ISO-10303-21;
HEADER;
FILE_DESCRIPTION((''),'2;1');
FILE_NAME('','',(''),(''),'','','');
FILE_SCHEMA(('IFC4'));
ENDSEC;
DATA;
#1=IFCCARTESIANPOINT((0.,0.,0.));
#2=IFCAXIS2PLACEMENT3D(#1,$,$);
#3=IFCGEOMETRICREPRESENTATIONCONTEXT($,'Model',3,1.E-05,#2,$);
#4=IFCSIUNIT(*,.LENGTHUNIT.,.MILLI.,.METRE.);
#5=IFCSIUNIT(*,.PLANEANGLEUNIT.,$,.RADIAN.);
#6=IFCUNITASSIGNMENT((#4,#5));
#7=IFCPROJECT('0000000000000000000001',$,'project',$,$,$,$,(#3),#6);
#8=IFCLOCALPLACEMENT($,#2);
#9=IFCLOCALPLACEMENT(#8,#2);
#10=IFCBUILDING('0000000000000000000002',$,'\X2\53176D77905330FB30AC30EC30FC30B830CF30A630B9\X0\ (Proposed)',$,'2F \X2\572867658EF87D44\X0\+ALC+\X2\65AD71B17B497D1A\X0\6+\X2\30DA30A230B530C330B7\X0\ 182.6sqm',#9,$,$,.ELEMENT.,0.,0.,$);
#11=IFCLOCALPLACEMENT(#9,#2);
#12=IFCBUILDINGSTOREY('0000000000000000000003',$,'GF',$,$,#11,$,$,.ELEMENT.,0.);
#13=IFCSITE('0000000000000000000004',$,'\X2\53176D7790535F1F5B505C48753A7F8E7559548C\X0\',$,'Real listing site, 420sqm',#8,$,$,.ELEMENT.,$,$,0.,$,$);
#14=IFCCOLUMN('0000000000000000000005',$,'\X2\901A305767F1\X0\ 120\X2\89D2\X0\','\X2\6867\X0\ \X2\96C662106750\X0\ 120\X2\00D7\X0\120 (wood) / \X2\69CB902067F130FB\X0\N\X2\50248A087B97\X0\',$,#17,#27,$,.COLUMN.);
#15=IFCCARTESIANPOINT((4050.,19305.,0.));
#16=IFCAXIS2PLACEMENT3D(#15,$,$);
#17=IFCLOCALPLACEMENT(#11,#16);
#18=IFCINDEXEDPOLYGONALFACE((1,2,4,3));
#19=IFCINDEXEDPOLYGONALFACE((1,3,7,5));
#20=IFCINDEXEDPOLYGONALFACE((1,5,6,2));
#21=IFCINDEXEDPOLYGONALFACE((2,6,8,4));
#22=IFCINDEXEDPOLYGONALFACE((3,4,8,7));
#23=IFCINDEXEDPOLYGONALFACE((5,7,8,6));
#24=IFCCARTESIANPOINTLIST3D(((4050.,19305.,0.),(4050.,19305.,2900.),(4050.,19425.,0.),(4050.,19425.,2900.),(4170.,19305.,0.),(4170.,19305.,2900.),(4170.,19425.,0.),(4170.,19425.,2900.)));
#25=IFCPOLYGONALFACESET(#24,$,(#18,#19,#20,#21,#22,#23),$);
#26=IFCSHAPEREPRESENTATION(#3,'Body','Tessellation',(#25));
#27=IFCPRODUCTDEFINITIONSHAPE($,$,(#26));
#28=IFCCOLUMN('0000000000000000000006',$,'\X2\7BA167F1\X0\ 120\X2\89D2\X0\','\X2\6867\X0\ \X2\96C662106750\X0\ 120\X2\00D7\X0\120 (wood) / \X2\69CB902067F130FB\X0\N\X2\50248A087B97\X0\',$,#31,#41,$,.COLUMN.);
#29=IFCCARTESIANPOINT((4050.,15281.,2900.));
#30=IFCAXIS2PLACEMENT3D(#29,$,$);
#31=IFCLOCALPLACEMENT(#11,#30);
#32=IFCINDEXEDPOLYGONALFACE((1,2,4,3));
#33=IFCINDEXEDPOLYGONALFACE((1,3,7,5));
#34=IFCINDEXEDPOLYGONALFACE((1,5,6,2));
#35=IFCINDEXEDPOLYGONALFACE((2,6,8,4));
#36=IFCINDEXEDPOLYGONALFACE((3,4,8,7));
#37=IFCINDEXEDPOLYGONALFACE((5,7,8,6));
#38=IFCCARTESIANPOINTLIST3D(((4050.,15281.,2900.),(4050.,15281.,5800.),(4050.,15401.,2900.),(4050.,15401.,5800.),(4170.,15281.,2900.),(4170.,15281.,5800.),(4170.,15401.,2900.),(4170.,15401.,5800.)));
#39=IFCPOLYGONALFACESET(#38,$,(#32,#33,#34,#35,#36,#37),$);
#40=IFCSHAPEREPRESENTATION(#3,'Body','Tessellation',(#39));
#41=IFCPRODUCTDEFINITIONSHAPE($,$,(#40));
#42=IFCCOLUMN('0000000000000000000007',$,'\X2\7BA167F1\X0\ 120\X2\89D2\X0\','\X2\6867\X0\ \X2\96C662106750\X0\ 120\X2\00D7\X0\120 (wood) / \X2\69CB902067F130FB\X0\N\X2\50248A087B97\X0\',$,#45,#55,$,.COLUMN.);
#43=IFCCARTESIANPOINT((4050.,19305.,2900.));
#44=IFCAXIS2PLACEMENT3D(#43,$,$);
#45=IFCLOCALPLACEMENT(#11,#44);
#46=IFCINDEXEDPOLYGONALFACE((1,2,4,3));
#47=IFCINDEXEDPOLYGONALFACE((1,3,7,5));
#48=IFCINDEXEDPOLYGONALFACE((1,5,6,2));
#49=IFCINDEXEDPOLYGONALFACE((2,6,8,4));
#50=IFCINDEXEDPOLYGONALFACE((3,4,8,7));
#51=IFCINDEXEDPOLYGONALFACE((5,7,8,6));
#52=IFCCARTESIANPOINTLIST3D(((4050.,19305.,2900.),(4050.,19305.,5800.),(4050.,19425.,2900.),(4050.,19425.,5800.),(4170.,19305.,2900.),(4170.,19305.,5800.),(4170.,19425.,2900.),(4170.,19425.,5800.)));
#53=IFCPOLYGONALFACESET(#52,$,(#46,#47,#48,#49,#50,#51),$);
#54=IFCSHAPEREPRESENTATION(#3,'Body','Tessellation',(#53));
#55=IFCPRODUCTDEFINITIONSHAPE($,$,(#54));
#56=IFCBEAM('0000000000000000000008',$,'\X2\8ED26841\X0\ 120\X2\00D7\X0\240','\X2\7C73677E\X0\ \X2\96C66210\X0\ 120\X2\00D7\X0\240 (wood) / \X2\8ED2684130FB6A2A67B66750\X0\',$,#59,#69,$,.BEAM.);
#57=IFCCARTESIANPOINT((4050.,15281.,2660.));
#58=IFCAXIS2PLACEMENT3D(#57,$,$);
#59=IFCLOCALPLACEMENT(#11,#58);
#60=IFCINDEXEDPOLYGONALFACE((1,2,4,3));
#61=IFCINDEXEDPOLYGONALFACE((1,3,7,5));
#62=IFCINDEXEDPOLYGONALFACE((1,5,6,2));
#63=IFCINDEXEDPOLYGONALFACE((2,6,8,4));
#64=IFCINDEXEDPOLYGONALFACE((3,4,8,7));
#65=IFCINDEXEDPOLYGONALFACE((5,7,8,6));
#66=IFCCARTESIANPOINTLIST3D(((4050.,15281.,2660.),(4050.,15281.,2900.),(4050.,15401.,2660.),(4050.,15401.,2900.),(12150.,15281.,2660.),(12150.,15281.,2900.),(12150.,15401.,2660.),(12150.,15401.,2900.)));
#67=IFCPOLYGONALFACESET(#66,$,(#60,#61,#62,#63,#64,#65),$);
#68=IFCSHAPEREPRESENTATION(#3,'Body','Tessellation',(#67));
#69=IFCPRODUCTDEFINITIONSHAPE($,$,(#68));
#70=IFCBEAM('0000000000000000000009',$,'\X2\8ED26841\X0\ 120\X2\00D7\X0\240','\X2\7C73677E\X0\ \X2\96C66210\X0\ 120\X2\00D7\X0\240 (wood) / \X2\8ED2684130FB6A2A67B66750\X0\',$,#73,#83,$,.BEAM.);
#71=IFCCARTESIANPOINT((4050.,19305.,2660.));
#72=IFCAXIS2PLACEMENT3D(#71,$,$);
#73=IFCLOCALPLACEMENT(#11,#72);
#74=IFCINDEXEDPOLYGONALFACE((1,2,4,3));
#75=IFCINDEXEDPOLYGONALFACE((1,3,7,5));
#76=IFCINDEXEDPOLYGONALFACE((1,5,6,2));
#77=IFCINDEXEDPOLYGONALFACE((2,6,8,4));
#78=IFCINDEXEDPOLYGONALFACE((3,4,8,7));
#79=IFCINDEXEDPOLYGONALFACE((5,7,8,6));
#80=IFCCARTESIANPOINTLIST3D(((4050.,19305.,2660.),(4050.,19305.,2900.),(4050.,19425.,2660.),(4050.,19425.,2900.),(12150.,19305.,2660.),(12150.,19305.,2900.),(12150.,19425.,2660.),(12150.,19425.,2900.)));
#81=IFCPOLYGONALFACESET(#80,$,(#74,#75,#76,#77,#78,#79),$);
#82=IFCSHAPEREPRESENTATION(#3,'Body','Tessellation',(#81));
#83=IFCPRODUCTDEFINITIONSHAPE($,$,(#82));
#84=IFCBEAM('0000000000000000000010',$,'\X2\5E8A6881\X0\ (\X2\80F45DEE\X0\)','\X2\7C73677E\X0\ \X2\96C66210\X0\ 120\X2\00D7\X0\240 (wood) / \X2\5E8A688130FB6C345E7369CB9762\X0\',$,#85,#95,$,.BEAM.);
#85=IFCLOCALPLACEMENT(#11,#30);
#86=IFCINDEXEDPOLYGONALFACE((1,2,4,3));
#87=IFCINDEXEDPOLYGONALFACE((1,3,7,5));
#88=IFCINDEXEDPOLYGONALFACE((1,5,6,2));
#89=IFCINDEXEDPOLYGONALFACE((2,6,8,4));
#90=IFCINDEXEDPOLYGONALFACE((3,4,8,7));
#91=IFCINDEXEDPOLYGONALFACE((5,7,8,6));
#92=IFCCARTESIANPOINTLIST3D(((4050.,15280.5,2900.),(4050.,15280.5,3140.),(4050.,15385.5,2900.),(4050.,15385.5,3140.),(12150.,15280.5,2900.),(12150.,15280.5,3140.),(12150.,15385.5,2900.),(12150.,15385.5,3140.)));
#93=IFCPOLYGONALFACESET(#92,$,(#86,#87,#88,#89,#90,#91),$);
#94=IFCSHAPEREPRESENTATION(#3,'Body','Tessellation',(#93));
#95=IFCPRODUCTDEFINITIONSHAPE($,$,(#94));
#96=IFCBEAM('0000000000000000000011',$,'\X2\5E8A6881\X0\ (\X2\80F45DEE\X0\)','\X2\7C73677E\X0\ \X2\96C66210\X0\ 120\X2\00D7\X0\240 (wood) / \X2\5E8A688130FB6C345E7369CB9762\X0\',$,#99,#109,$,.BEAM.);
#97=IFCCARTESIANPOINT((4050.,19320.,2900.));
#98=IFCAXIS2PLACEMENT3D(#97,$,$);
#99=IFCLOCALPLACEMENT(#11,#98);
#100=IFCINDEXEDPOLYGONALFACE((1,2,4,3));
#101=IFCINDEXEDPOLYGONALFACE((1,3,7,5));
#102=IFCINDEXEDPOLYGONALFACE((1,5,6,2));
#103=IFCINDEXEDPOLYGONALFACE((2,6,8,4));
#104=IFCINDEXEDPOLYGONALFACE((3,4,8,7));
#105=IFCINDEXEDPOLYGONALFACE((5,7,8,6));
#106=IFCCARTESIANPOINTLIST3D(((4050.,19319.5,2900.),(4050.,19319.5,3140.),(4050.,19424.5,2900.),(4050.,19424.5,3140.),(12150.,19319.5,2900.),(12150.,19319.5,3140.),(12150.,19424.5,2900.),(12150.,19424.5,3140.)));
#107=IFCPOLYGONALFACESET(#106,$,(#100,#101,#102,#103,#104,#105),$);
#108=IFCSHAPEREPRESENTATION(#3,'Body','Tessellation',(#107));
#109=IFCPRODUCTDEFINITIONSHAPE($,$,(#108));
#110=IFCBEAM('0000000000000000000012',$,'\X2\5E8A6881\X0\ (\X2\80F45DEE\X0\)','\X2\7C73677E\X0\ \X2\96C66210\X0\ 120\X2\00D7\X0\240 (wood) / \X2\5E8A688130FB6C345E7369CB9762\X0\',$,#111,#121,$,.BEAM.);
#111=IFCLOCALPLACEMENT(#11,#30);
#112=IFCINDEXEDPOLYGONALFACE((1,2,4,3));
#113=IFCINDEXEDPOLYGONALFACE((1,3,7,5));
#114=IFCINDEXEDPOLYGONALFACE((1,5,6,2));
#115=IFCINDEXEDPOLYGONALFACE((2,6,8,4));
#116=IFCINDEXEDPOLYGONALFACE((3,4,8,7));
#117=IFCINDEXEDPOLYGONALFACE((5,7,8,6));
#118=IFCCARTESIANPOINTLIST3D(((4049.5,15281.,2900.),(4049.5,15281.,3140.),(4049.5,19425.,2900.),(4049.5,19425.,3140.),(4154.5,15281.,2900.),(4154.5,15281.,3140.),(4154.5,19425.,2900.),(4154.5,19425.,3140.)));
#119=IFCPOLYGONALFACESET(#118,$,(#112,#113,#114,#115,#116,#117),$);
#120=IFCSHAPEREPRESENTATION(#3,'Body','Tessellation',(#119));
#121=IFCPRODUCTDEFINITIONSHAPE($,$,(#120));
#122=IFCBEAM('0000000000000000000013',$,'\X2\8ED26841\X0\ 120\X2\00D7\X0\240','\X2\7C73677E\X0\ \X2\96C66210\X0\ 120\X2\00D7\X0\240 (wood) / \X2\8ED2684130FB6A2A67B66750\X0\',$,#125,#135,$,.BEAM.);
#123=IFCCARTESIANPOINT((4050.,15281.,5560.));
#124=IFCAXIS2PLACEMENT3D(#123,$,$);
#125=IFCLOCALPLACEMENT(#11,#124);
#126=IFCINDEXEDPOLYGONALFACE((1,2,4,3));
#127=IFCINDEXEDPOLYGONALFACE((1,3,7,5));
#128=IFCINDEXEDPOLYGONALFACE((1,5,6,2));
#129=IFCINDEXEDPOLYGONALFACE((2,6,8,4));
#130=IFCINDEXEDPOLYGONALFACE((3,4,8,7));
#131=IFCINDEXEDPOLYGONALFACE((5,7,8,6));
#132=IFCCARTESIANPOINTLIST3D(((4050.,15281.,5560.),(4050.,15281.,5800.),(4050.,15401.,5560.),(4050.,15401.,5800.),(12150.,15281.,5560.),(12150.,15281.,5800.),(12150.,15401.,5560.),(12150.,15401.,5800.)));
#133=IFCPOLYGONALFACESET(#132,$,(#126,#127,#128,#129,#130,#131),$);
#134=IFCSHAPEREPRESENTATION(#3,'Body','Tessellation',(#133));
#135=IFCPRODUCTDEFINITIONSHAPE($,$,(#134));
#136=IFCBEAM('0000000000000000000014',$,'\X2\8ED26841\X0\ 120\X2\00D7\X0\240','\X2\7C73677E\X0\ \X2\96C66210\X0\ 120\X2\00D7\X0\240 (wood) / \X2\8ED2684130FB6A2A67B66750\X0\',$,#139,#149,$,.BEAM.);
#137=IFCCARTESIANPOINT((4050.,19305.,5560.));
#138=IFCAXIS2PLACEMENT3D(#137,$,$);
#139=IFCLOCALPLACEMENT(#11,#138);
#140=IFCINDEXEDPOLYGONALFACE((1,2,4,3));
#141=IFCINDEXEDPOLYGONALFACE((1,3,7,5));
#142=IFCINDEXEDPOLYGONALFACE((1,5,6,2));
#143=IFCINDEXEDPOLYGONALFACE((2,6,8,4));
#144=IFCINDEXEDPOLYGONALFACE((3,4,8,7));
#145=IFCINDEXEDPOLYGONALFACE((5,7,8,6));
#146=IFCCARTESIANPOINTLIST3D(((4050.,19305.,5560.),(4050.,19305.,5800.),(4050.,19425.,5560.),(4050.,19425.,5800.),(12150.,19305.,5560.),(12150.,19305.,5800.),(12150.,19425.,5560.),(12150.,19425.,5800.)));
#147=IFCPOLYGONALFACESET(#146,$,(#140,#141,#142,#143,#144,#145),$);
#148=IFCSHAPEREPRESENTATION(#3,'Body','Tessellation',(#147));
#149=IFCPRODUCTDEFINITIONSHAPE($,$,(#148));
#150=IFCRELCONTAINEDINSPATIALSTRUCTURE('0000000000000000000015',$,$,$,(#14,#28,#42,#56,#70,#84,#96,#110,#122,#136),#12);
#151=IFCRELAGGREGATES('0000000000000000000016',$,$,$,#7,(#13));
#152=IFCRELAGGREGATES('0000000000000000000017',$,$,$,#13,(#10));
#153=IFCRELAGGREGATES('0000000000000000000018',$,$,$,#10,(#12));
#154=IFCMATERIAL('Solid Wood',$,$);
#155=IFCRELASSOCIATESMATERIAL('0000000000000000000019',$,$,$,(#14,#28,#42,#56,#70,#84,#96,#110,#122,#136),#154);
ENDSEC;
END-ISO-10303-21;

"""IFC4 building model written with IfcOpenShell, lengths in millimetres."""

from ifc_helpers import new_model, si_unit, frame, frame_2d, origin, place, context, project, spatial, rectangle, extrude, material, element, save


model = new_model("IFC4")

# Units and contexts
model_context = context("Model", 3, precision=1e-05, world=origin())
ifc_project = project(units=[si_unit("LENGTHUNIT", "METRE", prefix="MILLI"), si_unit("PLANEANGLEUNIT", "RADIAN")], contexts=[model_context])

# Site, building, storey
site_placement = place(None, origin())
site = spatial("IfcSite", under=ifc_project, at=site_placement, Name="北海道弟子屈町美留和", ObjectType="Real listing site, 420sqm", CompositionType="ELEMENT", RefElevation=0.0)
building_placement = place(site_placement, origin())
building = spatial("IfcBuilding", under=site, at=building_placement, Name="北海道・ガレージハウス (Proposed)", ObjectType="2F 在来軸組+ALC+断熱等級6+ペアサッシ 182.6sqm", CompositionType="ELEMENT", ElevationOfRefHeight=0.0, ElevationOfTerrain=0.0)
storey_placement = place(building_placement, origin())
storey = spatial("IfcBuildingStorey", under=building, at=storey_placement, Name="GF", CompositionType="ELEMENT", Elevation=0.0)

# Columns
ifc_material_1 = material(Name="Solid Wood")
column_1_placement = place(storey_placement, frame((4050.0, 19305.0, 0.0)))
element("IfcColumn", 1, at=column_1_placement, inside=storey, material=ifc_material_1, Name="通し柱 120角", Description="桧 集成材 120×120 (wood) / 構造柱・N値計算", PredefinedType="COLUMN", context=model_context, shape_type="SweptSolid", body=[
    extrude(rectangle(XDim=120.0, YDim=120.0, at=frame_2d((60.0, 60.0))), frame((4050.0, 19305.0, 0.0)), (0.0, 0.0, 1.0), 2900.0),
])
column_2_placement = place(storey_placement, frame((4050.0, 15281.0, 2900.0)))
element("IfcColumn", 2, at=column_2_placement, inside=storey, material=ifc_material_1, Name="管柱 120角", Description="桧 集成材 120×120 (wood) / 構造柱・N値計算", PredefinedType="COLUMN", context=model_context, shape_type="SweptSolid", body=[
    extrude(rectangle(XDim=120.0, YDim=120.0, at=frame_2d((60.0, 60.0))), frame((4050.0, 15281.0, 2900.0)), (0.0, 0.0, 1.0), 2900.0),
])
column_3_placement = place(storey_placement, frame((4050.0, 19305.0, 2900.0)))
element("IfcColumn", 3, at=column_3_placement, inside=storey, material=ifc_material_1, Name="管柱 120角", Description="桧 集成材 120×120 (wood) / 構造柱・N値計算", PredefinedType="COLUMN", context=model_context, shape_type="SweptSolid", body=[
    extrude(rectangle(XDim=120.0, YDim=120.0, at=frame_2d((60.0, 60.0))), frame((4050.0, 19305.0, 2900.0)), (0.0, 0.0, 1.0), 2900.0),
])

# Beams
beam_1_placement = place(storey_placement, frame((4050.0, 15281.0, 2660.0)))
element("IfcBeam", 4, at=beam_1_placement, inside=storey, material=ifc_material_1, Name="軒桁 120×240", Description="米松 集成 120×240 (wood) / 軒桁・横架材", PredefinedType="BEAM", context=model_context, shape_type="SweptSolid", body=[
    extrude(rectangle(XDim=8100.0, YDim=120.0, at=frame_2d((4050.0, 60.0))), frame((4050.0, 15281.0, 2660.0)), (0.0, 0.0, 1.0), 240.0),
])
beam_2_placement = place(storey_placement, frame((4050.0, 19305.0, 2660.0)))
element("IfcBeam", 5, at=beam_2_placement, inside=storey, material=ifc_material_1, Name="軒桁 120×240", Description="米松 集成 120×240 (wood) / 軒桁・横架材", PredefinedType="BEAM", context=model_context, shape_type="SweptSolid", body=[
    extrude(rectangle(XDim=8100.0, YDim=120.0, at=frame_2d((4050.0, 60.0))), frame((4050.0, 19305.0, 2660.0)), (0.0, 0.0, 1.0), 240.0),
])
beam_3_placement = place(storey_placement, frame((4050.0, 15281.0, 2900.0)))
element("IfcBeam", 6, at=beam_3_placement, inside=storey, material=ifc_material_1, Name="床梁 (胴差)", Description="米松 集成 120×240 (wood) / 床梁・水平構面", PredefinedType="BEAM", context=model_context, shape_type="SweptSolid", body=[
    extrude(rectangle(XDim=8100.0, YDim=105.0, at=frame_2d((4050.0, 52.0))), frame((4050.0, 15281.0, 2900.0)), (0.0, 0.0, 1.0), 240.0),
])
beam_4_placement = place(storey_placement, frame((4050.0, 19320.0, 2900.0)))
element("IfcBeam", 7, at=beam_4_placement, inside=storey, material=ifc_material_1, Name="床梁 (胴差)", Description="米松 集成 120×240 (wood) / 床梁・水平構面", PredefinedType="BEAM", context=model_context, shape_type="SweptSolid", body=[
    extrude(rectangle(XDim=8100.0, YDim=105.0, at=frame_2d((4050.0, 52.0))), frame((4050.0, 19320.0, 2900.0)), (0.0, 0.0, 1.0), 240.0),
])
beam_5_placement = place(storey_placement, frame((4050.0, 15281.0, 2900.0)))
element("IfcBeam", 8, at=beam_5_placement, inside=storey, material=ifc_material_1, Name="床梁 (胴差)", Description="米松 集成 120×240 (wood) / 床梁・水平構面", PredefinedType="BEAM", context=model_context, shape_type="SweptSolid", body=[
    extrude(rectangle(XDim=105.0, YDim=4144.0, at=frame_2d((52.0, 2072.0))), frame((4050.0, 15281.0, 2900.0)), (0.0, 0.0, 1.0), 240.0),
])
beam_6_placement = place(storey_placement, frame((4050.0, 15281.0, 5560.0)))
element("IfcBeam", 9, at=beam_6_placement, inside=storey, material=ifc_material_1, Name="軒桁 120×240", Description="米松 集成 120×240 (wood) / 軒桁・横架材", PredefinedType="BEAM", context=model_context, shape_type="SweptSolid", body=[
    extrude(rectangle(XDim=8100.0, YDim=120.0, at=frame_2d((4050.0, 60.0))), frame((4050.0, 15281.0, 5560.0)), (0.0, 0.0, 1.0), 240.0),
])
beam_7_placement = place(storey_placement, frame((4050.0, 19305.0, 5560.0)))
element("IfcBeam", 10, at=beam_7_placement, inside=storey, material=ifc_material_1, Name="軒桁 120×240", Description="米松 集成 120×240 (wood) / 軒桁・横架材", PredefinedType="BEAM", context=model_context, shape_type="SweptSolid", body=[
    extrude(rectangle(XDim=8100.0, YDim=120.0, at=frame_2d((4050.0, 60.0))), frame((4050.0, 19305.0, 5560.0)), (0.0, 0.0, 1.0), 240.0),
])

save(model, "model.ifc")
